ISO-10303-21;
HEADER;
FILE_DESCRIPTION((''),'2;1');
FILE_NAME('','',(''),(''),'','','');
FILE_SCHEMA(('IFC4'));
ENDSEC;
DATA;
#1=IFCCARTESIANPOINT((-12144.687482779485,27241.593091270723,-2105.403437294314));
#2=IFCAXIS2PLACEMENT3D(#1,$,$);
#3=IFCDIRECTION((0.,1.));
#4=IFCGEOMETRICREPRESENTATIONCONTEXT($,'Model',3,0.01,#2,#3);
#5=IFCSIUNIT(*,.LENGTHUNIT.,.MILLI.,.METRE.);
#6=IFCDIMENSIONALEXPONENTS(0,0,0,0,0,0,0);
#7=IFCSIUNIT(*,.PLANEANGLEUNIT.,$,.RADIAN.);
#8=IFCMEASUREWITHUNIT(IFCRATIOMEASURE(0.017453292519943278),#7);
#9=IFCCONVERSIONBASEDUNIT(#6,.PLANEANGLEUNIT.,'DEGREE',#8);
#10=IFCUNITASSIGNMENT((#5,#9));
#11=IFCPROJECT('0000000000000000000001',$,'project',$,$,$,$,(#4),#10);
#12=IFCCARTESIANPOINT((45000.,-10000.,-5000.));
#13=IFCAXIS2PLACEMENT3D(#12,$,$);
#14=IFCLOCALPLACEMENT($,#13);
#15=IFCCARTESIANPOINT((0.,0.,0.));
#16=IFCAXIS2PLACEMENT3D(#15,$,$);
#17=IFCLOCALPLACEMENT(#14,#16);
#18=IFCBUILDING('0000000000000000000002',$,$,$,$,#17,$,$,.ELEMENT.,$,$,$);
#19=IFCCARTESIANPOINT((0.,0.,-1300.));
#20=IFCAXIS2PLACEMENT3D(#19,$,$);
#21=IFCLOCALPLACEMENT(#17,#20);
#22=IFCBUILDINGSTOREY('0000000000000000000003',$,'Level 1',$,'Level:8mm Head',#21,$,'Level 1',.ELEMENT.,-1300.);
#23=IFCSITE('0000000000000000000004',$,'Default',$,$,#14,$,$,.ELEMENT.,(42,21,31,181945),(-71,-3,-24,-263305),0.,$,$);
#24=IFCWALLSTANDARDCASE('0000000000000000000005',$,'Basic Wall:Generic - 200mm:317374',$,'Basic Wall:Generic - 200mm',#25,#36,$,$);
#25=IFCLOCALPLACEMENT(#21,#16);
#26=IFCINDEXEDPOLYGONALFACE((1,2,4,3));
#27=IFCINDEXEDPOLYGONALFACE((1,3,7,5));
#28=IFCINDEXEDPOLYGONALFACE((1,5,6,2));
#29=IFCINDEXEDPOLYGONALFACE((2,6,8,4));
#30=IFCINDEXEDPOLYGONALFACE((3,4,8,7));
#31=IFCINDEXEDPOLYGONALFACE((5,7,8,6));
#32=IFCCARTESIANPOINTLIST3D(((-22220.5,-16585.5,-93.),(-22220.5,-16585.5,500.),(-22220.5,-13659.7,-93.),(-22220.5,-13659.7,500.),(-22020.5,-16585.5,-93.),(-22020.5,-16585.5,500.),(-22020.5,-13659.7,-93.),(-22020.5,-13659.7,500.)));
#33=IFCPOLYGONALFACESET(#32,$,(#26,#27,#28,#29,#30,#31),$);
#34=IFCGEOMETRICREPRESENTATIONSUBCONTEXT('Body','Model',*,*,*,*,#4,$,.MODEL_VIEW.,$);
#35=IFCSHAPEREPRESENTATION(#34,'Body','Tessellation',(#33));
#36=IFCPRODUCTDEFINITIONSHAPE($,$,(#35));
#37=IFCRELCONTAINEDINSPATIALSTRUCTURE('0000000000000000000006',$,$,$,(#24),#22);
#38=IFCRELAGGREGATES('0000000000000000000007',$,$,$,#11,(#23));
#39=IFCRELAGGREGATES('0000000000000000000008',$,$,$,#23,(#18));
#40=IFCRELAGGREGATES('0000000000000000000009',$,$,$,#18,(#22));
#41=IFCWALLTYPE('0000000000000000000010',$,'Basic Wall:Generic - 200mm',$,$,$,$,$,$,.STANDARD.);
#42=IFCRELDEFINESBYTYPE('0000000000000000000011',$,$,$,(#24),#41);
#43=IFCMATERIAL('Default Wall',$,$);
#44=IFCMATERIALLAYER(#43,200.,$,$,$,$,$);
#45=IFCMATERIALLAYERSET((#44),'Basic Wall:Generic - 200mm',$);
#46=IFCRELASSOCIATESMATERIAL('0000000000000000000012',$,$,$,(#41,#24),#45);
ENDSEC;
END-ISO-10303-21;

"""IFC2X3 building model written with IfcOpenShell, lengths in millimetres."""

from ifc_helpers import new_model, entity, si_unit, converted_unit, direction, frame, frame_2d, origin, place, context, subcontext, project, spatial, polyline, rectangle, extrude, clip, bounded_halfspace, material, layer, layer_set, layer_usage, type_object, element, save


model = new_model("IFC2X3")

# Units and contexts
model_context = context("Model", 3, precision=0.01, world=frame((-12144.687482779485, 27241.593091270723, -2105.403437294314)), true_north=direction((0.0, 1.0)))
body_context = subcontext(model_context, "Body", "Model", "MODEL_VIEW")
ifc_project = project(units=[si_unit("LENGTHUNIT", "METRE", prefix="MILLI"), converted_unit("PLANEANGLEUNIT", "DEGREE", entity("IfcRatioMeasure", 0.017453292519943278), si_unit("PLANEANGLEUNIT", "RADIAN"), dimensions=[0, 0, 0, 0, 0, 0, 0])], contexts=[model_context])

# Site, building, storey
site_placement = place(None, frame((45000.0, -10000.0, -5000.0)))
site = spatial("IfcSite", under=ifc_project, at=site_placement, Name="Default", CompositionType="ELEMENT", RefLatitude=(42, 21, 31, 181945), RefLongitude=(-71, -3, -24, -263305), RefElevation=0.0)
building_placement = place(site_placement, origin())
building = spatial("IfcBuilding", under=site, at=building_placement, CompositionType="ELEMENT")
storey_placement = place(building_placement, frame((0.0, 0.0, -1300.0)))
storey = spatial("IfcBuildingStorey", under=building, at=storey_placement, Name="Level 1", ObjectType="Level:8mm Head", LongName="Level 1", CompositionType="ELEMENT", Elevation=-1300.0)

# Wall
ifc_material = material(Name="Default Wall")
ifc_layer = layer(ifc_material, 200.0)
ifc_layer_set = layer_set([ifc_layer], Name="Basic Wall:Generic - 200mm")
wall_type = type_object("IfcWallType", Name="Basic Wall:Generic - 200mm", PredefinedType="STANDARD", material=ifc_layer_set)
ifc_layer_usage_1 = layer_usage(ifc_layer_set, "AXIS2", "NEGATIVE", 100.0)
wall_1_placement = place(storey_placement, frame((-22120.5, -13659.7, -93.0), z_axis=(0.0, 0.0, 1.0), x_axis=(0.0, -1.0, 0.0)))
element("IfcWallStandardCase", 1, at=wall_1_placement, inside=storey, type_object=wall_type, material=ifc_layer_usage_1, Name="Basic Wall:Generic - 200mm:317374", ObjectType="Basic Wall:Generic - 200mm", context=body_context, shape_type="Clipping", body=[
    clip(extrude(rectangle(XDim=2925.8, YDim=200.0, at=frame_2d((1462.9, 0.0), x_axis=(-1.0, 0.0))), origin(), (0.0, 0.0, 1.0), 593.0), bounded_halfspace(frame((2925.8, -100.0, 0.0), z_axis=(0.0, 0.0, 1.0), x_axis=(0.0, -1.0, 0.0)), True, frame((2925.8, -100.0, 0.0), z_axis=(0.0, 0.0, 1.0), x_axis=(0.0, -1.0, 0.0)), polyline([(0.0, 0.0), (-60960.0, 0.0), (-60960.0, -891789.6), (0.0, -891789.6), (0.0, 0.0)]))),
])

save(model, "model.ifc")
